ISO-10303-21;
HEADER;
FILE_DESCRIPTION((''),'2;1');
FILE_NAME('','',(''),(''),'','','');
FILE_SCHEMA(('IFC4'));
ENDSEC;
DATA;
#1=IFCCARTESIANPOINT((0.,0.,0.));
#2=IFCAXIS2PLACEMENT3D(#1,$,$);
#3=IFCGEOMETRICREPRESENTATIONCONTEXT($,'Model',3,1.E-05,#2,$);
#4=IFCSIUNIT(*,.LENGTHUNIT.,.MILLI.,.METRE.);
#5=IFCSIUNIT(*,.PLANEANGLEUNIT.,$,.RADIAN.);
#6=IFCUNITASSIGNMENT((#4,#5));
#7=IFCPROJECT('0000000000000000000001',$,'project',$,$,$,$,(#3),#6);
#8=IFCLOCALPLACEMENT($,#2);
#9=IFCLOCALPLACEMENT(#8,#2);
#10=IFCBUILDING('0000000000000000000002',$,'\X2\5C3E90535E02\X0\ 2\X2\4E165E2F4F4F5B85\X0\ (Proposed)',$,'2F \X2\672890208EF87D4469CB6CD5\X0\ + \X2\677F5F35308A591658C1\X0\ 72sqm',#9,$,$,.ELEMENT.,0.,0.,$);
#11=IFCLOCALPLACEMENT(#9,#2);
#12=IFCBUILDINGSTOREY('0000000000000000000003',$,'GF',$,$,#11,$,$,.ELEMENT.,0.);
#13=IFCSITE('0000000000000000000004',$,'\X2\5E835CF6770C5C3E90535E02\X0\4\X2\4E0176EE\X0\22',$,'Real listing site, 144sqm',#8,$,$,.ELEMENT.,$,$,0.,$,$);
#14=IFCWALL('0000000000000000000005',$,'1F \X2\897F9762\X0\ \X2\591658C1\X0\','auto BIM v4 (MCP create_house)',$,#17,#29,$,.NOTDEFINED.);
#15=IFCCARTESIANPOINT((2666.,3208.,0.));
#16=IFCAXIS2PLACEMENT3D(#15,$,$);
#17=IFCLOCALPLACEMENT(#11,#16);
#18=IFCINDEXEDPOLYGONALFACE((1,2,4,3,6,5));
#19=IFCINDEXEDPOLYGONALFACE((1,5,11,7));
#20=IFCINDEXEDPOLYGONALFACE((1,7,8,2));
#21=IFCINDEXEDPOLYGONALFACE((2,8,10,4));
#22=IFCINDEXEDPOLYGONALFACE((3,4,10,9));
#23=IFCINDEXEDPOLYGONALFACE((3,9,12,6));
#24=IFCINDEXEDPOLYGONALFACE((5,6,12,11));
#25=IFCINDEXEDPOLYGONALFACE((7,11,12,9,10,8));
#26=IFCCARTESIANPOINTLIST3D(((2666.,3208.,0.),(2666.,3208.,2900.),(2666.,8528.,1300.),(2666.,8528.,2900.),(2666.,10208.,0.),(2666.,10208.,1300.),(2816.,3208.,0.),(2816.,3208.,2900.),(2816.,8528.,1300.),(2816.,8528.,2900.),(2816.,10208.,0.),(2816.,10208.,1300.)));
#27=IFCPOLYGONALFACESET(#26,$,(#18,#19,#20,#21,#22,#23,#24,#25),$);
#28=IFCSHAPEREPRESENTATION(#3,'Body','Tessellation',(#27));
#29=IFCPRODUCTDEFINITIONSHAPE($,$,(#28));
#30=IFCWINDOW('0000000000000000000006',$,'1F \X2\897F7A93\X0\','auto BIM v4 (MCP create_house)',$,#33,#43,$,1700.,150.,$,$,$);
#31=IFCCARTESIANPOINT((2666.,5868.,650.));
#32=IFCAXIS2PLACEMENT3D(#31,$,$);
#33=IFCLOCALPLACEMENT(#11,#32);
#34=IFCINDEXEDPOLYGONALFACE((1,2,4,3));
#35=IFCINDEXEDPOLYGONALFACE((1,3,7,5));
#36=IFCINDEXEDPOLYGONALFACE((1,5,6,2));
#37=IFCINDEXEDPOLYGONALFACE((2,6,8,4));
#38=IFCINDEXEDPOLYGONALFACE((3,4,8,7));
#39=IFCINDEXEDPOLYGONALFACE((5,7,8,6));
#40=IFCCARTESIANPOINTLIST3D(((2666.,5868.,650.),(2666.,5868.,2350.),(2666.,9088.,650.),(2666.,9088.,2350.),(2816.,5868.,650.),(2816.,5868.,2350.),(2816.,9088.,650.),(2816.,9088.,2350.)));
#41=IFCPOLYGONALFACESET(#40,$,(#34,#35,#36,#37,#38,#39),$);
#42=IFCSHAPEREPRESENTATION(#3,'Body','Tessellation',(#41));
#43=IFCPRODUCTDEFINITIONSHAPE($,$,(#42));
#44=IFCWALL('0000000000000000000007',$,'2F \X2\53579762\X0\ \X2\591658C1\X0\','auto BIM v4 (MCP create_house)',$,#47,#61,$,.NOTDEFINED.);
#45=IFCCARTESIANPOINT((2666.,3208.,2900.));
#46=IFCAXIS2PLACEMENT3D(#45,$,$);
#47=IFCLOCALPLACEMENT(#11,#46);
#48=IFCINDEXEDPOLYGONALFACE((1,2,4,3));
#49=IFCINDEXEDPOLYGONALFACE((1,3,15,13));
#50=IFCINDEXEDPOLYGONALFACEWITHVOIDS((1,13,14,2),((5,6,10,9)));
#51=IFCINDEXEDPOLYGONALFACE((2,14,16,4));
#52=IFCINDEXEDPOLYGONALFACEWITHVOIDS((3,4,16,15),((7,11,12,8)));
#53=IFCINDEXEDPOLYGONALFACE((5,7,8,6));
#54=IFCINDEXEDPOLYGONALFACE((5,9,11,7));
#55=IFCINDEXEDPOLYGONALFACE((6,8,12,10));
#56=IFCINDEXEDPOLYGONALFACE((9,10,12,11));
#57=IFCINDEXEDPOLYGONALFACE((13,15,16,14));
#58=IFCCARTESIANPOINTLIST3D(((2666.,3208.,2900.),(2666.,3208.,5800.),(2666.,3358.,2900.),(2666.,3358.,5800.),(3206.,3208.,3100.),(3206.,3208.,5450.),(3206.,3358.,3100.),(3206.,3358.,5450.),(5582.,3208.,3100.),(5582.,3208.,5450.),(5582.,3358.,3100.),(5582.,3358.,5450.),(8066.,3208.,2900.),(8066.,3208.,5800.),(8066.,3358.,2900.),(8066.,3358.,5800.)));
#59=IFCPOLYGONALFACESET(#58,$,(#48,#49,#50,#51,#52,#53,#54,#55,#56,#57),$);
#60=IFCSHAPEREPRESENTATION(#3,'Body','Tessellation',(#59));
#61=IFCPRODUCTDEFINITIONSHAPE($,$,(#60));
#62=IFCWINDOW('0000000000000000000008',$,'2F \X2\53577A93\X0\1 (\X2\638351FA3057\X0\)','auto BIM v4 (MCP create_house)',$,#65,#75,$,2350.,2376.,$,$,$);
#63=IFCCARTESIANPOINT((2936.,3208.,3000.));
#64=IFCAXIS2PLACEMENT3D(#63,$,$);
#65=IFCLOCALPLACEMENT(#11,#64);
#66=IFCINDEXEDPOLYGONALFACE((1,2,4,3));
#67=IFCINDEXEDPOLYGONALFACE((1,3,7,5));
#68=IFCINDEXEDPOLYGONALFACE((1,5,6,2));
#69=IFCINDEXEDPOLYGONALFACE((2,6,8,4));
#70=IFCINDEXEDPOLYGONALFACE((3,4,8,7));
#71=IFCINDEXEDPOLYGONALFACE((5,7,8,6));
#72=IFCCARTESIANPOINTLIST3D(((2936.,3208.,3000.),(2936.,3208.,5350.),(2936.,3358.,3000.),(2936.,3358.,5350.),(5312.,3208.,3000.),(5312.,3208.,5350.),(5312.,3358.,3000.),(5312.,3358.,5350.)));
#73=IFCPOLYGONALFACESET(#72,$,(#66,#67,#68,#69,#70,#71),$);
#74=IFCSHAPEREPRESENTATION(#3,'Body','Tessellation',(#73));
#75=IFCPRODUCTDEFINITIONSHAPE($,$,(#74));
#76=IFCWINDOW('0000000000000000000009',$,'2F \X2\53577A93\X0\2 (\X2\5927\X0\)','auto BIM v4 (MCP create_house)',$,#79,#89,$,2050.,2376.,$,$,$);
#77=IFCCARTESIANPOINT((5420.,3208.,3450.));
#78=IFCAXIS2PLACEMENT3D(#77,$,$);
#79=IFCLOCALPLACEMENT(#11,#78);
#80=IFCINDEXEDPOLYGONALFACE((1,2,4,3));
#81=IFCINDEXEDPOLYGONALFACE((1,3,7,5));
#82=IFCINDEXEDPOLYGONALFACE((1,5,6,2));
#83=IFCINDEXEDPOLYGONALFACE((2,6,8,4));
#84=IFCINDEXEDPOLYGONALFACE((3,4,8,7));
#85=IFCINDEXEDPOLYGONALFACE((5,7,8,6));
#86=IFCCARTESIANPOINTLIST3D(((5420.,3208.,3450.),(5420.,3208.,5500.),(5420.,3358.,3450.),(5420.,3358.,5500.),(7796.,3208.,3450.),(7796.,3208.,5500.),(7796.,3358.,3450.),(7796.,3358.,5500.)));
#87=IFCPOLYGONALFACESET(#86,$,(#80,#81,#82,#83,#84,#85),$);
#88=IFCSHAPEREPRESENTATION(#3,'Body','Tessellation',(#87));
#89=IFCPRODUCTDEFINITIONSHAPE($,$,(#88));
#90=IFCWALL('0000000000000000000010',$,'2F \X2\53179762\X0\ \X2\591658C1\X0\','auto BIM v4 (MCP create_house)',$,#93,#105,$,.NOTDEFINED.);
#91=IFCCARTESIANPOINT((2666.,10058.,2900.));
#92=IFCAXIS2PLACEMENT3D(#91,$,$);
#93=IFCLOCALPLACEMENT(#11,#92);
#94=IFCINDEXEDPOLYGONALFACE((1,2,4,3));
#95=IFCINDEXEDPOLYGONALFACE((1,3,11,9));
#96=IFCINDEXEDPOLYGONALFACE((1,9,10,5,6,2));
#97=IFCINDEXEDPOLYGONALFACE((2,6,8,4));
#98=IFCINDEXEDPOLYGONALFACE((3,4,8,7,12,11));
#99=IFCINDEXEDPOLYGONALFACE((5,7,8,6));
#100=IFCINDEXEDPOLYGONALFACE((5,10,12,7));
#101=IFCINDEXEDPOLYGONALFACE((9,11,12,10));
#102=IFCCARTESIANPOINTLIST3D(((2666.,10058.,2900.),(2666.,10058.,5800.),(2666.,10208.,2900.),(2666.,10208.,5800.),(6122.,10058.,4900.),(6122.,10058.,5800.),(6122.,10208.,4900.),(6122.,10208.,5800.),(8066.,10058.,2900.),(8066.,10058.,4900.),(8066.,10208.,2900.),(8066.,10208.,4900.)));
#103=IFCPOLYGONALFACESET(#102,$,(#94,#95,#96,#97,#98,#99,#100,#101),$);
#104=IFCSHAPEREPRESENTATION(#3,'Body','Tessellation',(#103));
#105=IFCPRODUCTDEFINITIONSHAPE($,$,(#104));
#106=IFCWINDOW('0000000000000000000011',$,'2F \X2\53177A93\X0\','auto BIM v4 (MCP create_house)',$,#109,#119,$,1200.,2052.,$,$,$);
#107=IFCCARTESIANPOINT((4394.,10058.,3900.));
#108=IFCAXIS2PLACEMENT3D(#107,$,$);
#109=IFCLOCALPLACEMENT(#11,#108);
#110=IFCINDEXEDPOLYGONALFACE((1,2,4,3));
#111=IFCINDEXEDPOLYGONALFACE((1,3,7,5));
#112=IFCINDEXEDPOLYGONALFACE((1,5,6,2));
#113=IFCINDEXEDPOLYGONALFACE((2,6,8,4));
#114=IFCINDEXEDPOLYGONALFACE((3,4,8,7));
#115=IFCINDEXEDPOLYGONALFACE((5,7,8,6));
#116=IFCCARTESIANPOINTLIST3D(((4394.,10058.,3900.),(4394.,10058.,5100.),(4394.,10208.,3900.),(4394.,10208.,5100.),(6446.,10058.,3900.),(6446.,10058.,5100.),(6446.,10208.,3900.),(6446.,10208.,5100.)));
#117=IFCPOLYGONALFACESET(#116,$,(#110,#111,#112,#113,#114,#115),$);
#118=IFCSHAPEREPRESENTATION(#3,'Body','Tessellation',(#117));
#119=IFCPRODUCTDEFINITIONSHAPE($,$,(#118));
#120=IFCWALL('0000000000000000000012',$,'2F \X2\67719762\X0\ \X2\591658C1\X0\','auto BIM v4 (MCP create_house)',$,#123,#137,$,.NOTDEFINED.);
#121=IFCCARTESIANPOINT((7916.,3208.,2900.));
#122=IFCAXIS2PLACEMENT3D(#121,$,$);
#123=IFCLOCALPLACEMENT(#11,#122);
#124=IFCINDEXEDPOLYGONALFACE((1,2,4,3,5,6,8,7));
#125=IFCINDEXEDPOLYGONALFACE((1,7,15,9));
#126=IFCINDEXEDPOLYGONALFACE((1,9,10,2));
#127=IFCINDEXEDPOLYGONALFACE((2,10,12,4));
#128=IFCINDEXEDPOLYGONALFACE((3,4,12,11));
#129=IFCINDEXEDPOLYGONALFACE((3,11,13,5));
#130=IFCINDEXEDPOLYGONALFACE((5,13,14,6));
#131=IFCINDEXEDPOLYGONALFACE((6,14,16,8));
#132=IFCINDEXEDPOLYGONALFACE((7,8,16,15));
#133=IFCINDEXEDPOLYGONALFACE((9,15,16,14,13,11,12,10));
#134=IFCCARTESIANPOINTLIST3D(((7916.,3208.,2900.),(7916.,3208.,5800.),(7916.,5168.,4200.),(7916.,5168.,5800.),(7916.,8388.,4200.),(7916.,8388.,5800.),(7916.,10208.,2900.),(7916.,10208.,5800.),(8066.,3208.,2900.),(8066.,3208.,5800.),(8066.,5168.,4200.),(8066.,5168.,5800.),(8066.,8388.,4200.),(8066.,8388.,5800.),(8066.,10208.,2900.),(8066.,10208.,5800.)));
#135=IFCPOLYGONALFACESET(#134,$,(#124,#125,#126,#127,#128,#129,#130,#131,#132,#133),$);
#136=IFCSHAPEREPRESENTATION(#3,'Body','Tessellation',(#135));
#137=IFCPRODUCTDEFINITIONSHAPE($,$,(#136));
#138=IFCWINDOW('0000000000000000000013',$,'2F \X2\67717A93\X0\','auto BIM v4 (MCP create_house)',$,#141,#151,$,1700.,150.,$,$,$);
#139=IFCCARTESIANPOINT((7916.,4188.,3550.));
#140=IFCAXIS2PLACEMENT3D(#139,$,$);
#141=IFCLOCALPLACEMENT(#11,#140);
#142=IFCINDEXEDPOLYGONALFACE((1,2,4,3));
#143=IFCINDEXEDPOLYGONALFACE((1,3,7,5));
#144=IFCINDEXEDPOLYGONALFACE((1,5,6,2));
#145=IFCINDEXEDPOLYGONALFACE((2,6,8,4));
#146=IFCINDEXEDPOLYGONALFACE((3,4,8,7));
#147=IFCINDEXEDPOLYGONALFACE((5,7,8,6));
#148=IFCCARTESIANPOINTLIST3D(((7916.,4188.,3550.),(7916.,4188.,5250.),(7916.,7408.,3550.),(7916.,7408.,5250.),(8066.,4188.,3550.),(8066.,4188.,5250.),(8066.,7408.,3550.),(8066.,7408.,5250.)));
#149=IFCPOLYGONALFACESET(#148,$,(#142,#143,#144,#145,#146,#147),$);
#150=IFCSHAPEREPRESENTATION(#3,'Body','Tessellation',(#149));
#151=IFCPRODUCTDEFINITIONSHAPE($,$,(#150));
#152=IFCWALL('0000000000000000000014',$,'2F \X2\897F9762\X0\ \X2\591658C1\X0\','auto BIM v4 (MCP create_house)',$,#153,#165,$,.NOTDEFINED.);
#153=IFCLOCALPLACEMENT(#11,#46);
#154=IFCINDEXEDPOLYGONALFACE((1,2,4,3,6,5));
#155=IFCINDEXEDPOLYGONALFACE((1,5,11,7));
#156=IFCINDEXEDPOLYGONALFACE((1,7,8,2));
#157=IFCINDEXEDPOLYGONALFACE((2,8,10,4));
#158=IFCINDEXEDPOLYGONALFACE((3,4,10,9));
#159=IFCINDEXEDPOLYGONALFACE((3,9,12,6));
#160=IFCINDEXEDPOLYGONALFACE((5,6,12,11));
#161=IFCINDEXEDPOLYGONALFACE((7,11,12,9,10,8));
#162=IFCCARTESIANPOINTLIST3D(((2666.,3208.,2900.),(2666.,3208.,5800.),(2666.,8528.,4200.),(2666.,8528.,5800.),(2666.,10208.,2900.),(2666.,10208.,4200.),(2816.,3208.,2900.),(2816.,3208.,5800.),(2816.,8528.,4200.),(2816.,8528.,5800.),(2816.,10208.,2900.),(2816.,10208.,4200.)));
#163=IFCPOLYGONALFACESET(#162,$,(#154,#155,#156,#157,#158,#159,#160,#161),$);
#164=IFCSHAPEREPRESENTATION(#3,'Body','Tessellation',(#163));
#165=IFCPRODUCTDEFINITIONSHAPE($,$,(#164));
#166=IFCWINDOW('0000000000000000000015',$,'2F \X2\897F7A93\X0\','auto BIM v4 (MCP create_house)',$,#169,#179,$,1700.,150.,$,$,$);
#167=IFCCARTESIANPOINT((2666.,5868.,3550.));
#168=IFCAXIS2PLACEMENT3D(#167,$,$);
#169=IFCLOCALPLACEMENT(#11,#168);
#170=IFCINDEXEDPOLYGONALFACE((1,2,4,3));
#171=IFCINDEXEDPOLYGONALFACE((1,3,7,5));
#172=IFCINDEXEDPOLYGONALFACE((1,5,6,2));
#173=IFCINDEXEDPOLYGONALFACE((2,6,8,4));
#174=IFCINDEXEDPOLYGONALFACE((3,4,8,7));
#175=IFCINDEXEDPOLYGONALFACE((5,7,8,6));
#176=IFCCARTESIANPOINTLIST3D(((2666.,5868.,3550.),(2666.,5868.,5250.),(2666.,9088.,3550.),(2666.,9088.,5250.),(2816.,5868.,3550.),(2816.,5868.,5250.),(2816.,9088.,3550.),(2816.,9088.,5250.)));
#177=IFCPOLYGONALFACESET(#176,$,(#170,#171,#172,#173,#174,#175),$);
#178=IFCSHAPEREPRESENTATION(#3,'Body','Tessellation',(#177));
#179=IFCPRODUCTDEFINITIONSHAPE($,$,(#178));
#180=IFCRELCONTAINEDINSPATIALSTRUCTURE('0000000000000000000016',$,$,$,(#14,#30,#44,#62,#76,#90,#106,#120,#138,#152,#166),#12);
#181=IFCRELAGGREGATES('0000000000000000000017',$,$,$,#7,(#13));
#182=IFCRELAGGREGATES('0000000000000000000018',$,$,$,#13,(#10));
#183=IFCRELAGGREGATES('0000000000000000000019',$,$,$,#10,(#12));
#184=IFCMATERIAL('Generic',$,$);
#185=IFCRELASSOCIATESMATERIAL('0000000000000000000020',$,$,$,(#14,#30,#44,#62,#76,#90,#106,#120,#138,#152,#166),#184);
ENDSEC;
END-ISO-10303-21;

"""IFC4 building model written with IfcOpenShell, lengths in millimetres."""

from ifc_helpers import new_model, si_unit, frame, frame_2d, origin, place, context, project, spatial, rectangle, extrude, material, element, fill, save


model = new_model("IFC4")

# Units and contexts
model_context = context("Model", 3, precision=1e-05, world=origin())
ifc_project = project(units=[si_unit("LENGTHUNIT", "METRE", prefix="MILLI"), si_unit("PLANEANGLEUNIT", "RADIAN")], contexts=[model_context])

# Site, building, storey
site_placement = place(None, origin())
site = spatial("IfcSite", under=ifc_project, at=site_placement, Name="広島県尾道市4丁目22", ObjectType="Real listing site, 144sqm", CompositionType="ELEMENT", RefElevation=0.0)
building_placement = place(site_placement, origin())
building = spatial("IfcBuilding", under=site, at=building_placement, Name="尾道市 2世帯住宅 (Proposed)", ObjectType="2F 木造軸組構法 + 板張り外壁 72sqm", CompositionType="ELEMENT", ElevationOfRefHeight=0.0, ElevationOfTerrain=0.0)
storey_placement = place(building_placement, origin())
storey = spatial("IfcBuildingStorey", under=building, at=storey_placement, Name="GF", CompositionType="ELEMENT", Elevation=0.0)

# Shared definitions
ifc_material = material(Name="Generic")

# Wall, opening, window
wall_1_placement = place(storey_placement, frame((2666.0, 3208.0, 0.0)))
wall_1 = element("IfcWall", 1, at=wall_1_placement, inside=storey, material=ifc_material, Name="1F 西面 外壁", Description="auto BIM v4 (MCP create_house)", PredefinedType="NOTDEFINED", context=model_context, shape_type="SweptSolid", body=[
    extrude(rectangle(XDim=150.0, YDim=7000.0, at=frame_2d((75.0, 3500.0))), frame((2666.0, 3208.0, 0.0)), (0.0, 0.0, 1.0), 2900.0),
])
opening_1_placement = place(storey_placement, frame((2666.0, 5868.0, 650.0)))
opening_1 = element("IfcOpeningElement", 2, at=opening_1_placement, cuts=wall_1, PredefinedType="NOTDEFINED", context=model_context, shape_type="SweptSolid", body=[
    extrude(rectangle(XDim=150.0, YDim=3220.0, at=frame_2d((75.0, 1610.0))), frame((2666.0, 5868.0, 650.0)), (0.0, 0.0, 1.0), 1700.0),
])
window_1_placement = place(storey_placement, frame((2666.0, 5868.0, 650.0)))
window_1 = element("IfcWindow", 3, at=window_1_placement, inside=storey, material=ifc_material, Name="1F 西窓", Description="auto BIM v4 (MCP create_house)", OverallHeight=1700.0, OverallWidth=150.0, context=model_context, shape_type="SweptSolid", body=[
    extrude(rectangle(XDim=150.0, YDim=3220.0, at=frame_2d((75.0, 1610.0))), frame((2666.0, 5868.0, 650.0)), (0.0, 0.0, 1.0), 1700.0),
])
fill(opening_1, window_1)

# Wall, openings, windows
wall_2_placement = place(storey_placement, frame((2666.0, 3208.0, 2900.0)))
wall_2 = element("IfcWall", 4, at=wall_2_placement, inside=storey, material=ifc_material, Name="2F 南面 外壁", Description="auto BIM v4 (MCP create_house)", PredefinedType="NOTDEFINED", context=model_context, shape_type="SweptSolid", body=[
    extrude(rectangle(XDim=5400.0, YDim=150.0, at=frame_2d((2700.0, 75.0))), frame((2666.0, 3208.0, 2900.0)), (0.0, 0.0, 1.0), 2900.0),
])
opening_2_placement = place(storey_placement, frame((2936.0, 3208.0, 3000.0)))
opening_2 = element("IfcOpeningElement", 5, at=opening_2_placement, cuts=wall_2, PredefinedType="NOTDEFINED", context=model_context, shape_type="SweptSolid", body=[
    extrude(rectangle(XDim=2376.0, YDim=150.0, at=frame_2d((1188.0, 75.0))), frame((2936.0, 3208.0, 3000.0)), (0.0, 0.0, 1.0), 2350.0),
])
opening_3_placement = place(storey_placement, frame((5420.0, 3208.0, 3450.0)))
opening_3 = element("IfcOpeningElement", 6, at=opening_3_placement, cuts=wall_2, PredefinedType="NOTDEFINED", context=model_context, shape_type="SweptSolid", body=[
    extrude(rectangle(XDim=2376.0, YDim=150.0, at=frame_2d((1188.0, 75.0))), frame((5420.0, 3208.0, 3450.0)), (0.0, 0.0, 1.0), 2050.0),
])
window_2_placement = place(storey_placement, frame((2936.0, 3208.0, 3000.0)))
window_2 = element("IfcWindow", 7, at=window_2_placement, inside=storey, material=ifc_material, Name="2F 南窓1 (掃出し)", Description="auto BIM v4 (MCP create_house)", OverallHeight=2350.0, OverallWidth=2376.0, context=model_context, shape_type="SweptSolid", body=[
    extrude(rectangle(XDim=2376.0, YDim=150.0, at=frame_2d((1188.0, 75.0))), frame((2936.0, 3208.0, 3000.0)), (0.0, 0.0, 1.0), 2350.0),
])
fill(opening_2, window_2)
window_3_placement = place(storey_placement, frame((5420.0, 3208.0, 3450.0)))
window_3 = element("IfcWindow", 8, at=window_3_placement, inside=storey, material=ifc_material, Name="2F 南窓2 (大)", Description="auto BIM v4 (MCP create_house)", OverallHeight=2050.0, OverallWidth=2376.0, context=model_context, shape_type="SweptSolid", body=[
    extrude(rectangle(XDim=2376.0, YDim=150.0, at=frame_2d((1188.0, 75.0))), frame((5420.0, 3208.0, 3450.0)), (0.0, 0.0, 1.0), 2050.0),
])
fill(opening_3, window_3)

# Walls, openings, windows
wall_3_placement = place(storey_placement, frame((2666.0, 10058.0, 2900.0)))
wall_3 = element("IfcWall", 9, at=wall_3_placement, inside=storey, material=ifc_material, Name="2F 北面 外壁", Description="auto BIM v4 (MCP create_house)", PredefinedType="NOTDEFINED", context=model_context, shape_type="SweptSolid", body=[
    extrude(rectangle(XDim=5400.0, YDim=150.0, at=frame_2d((2700.0, 75.0))), frame((2666.0, 10058.0, 2900.0)), (0.0, 0.0, 1.0), 2900.0),
])
opening_4_placement = place(storey_placement, frame((4394.0, 10058.0, 3900.0)))
opening_4 = element("IfcOpeningElement", 10, at=opening_4_placement, cuts=wall_3, PredefinedType="NOTDEFINED", context=model_context, shape_type="SweptSolid", body=[
    extrude(rectangle(XDim=2052.0, YDim=150.0, at=frame_2d((1026.0, 75.0))), frame((4394.0, 10058.0, 3900.0)), (0.0, 0.0, 1.0), 1200.0),
])
window_4_placement = place(storey_placement, frame((4394.0, 10058.0, 3900.0)))
window_4 = element("IfcWindow", 11, at=window_4_placement, inside=storey, material=ifc_material, Name="2F 北窓", Description="auto BIM v4 (MCP create_house)", OverallHeight=1200.0, OverallWidth=2052.0, context=model_context, shape_type="SweptSolid", body=[
    extrude(rectangle(XDim=2052.0, YDim=150.0, at=frame_2d((1026.0, 75.0))), frame((4394.0, 10058.0, 3900.0)), (0.0, 0.0, 1.0), 1200.0),
])
fill(opening_4, window_4)
wall_4_placement = place(storey_placement, frame((7916.0, 3208.0, 2900.0)))
wall_4 = element("IfcWall", 12, at=wall_4_placement, inside=storey, material=ifc_material, Name="2F 東面 外壁", Description="auto BIM v4 (MCP create_house)", PredefinedType="NOTDEFINED", context=model_context, shape_type="SweptSolid", body=[
    extrude(rectangle(XDim=150.0, YDim=7000.0, at=frame_2d((75.0, 3500.0))), frame((7916.0, 3208.0, 2900.0)), (0.0, 0.0, 1.0), 2900.0),
])
opening_5_placement = place(storey_placement, frame((7916.0, 4188.0, 3550.0)))
opening_5 = element("IfcOpeningElement", 13, at=opening_5_placement, cuts=wall_4, PredefinedType="NOTDEFINED", context=model_context, shape_type="SweptSolid", body=[
    extrude(rectangle(XDim=150.0, YDim=3220.0, at=frame_2d((75.0, 1610.0))), frame((7916.0, 4188.0, 3550.0)), (0.0, 0.0, 1.0), 1700.0),
])
window_5_placement = place(storey_placement, frame((7916.0, 4188.0, 3550.0)))
window_5 = element("IfcWindow", 14, at=window_5_placement, inside=storey, material=ifc_material, Name="2F 東窓", Description="auto BIM v4 (MCP create_house)", OverallHeight=1700.0, OverallWidth=150.0, context=model_context, shape_type="SweptSolid", body=[
    extrude(rectangle(XDim=150.0, YDim=3220.0, at=frame_2d((75.0, 1610.0))), frame((7916.0, 4188.0, 3550.0)), (0.0, 0.0, 1.0), 1700.0),
])
fill(opening_5, window_5)
wall_5_placement = place(storey_placement, frame((2666.0, 3208.0, 2900.0)))
wall_5 = element("IfcWall", 15, at=wall_5_placement, inside=storey, material=ifc_material, Name="2F 西面 外壁", Description="auto BIM v4 (MCP create_house)", PredefinedType="NOTDEFINED", context=model_context, shape_type="SweptSolid", body=[
    extrude(rectangle(XDim=150.0, YDim=7000.0, at=frame_2d((75.0, 3500.0))), frame((2666.0, 3208.0, 2900.0)), (0.0, 0.0, 1.0), 2900.0),
])
opening_6_placement = place(storey_placement, frame((2666.0, 5868.0, 3550.0)))
opening_6 = element("IfcOpeningElement", 16, at=opening_6_placement, cuts=wall_5, PredefinedType="NOTDEFINED", context=model_context, shape_type="SweptSolid", body=[
    extrude(rectangle(XDim=150.0, YDim=3220.0, at=frame_2d((75.0, 1610.0))), frame((2666.0, 5868.0, 3550.0)), (0.0, 0.0, 1.0), 1700.0),
])
window_6_placement = place(storey_placement, frame((2666.0, 5868.0, 3550.0)))
window_6 = element("IfcWindow", 17, at=window_6_placement, inside=storey, material=ifc_material, Name="2F 西窓", Description="auto BIM v4 (MCP create_house)", OverallHeight=1700.0, OverallWidth=150.0, context=model_context, shape_type="SweptSolid", body=[
    extrude(rectangle(XDim=150.0, YDim=3220.0, at=frame_2d((75.0, 1610.0))), frame((2666.0, 5868.0, 3550.0)), (0.0, 0.0, 1.0), 1700.0),
])
fill(opening_6, window_6)

save(model, "model.ifc")
